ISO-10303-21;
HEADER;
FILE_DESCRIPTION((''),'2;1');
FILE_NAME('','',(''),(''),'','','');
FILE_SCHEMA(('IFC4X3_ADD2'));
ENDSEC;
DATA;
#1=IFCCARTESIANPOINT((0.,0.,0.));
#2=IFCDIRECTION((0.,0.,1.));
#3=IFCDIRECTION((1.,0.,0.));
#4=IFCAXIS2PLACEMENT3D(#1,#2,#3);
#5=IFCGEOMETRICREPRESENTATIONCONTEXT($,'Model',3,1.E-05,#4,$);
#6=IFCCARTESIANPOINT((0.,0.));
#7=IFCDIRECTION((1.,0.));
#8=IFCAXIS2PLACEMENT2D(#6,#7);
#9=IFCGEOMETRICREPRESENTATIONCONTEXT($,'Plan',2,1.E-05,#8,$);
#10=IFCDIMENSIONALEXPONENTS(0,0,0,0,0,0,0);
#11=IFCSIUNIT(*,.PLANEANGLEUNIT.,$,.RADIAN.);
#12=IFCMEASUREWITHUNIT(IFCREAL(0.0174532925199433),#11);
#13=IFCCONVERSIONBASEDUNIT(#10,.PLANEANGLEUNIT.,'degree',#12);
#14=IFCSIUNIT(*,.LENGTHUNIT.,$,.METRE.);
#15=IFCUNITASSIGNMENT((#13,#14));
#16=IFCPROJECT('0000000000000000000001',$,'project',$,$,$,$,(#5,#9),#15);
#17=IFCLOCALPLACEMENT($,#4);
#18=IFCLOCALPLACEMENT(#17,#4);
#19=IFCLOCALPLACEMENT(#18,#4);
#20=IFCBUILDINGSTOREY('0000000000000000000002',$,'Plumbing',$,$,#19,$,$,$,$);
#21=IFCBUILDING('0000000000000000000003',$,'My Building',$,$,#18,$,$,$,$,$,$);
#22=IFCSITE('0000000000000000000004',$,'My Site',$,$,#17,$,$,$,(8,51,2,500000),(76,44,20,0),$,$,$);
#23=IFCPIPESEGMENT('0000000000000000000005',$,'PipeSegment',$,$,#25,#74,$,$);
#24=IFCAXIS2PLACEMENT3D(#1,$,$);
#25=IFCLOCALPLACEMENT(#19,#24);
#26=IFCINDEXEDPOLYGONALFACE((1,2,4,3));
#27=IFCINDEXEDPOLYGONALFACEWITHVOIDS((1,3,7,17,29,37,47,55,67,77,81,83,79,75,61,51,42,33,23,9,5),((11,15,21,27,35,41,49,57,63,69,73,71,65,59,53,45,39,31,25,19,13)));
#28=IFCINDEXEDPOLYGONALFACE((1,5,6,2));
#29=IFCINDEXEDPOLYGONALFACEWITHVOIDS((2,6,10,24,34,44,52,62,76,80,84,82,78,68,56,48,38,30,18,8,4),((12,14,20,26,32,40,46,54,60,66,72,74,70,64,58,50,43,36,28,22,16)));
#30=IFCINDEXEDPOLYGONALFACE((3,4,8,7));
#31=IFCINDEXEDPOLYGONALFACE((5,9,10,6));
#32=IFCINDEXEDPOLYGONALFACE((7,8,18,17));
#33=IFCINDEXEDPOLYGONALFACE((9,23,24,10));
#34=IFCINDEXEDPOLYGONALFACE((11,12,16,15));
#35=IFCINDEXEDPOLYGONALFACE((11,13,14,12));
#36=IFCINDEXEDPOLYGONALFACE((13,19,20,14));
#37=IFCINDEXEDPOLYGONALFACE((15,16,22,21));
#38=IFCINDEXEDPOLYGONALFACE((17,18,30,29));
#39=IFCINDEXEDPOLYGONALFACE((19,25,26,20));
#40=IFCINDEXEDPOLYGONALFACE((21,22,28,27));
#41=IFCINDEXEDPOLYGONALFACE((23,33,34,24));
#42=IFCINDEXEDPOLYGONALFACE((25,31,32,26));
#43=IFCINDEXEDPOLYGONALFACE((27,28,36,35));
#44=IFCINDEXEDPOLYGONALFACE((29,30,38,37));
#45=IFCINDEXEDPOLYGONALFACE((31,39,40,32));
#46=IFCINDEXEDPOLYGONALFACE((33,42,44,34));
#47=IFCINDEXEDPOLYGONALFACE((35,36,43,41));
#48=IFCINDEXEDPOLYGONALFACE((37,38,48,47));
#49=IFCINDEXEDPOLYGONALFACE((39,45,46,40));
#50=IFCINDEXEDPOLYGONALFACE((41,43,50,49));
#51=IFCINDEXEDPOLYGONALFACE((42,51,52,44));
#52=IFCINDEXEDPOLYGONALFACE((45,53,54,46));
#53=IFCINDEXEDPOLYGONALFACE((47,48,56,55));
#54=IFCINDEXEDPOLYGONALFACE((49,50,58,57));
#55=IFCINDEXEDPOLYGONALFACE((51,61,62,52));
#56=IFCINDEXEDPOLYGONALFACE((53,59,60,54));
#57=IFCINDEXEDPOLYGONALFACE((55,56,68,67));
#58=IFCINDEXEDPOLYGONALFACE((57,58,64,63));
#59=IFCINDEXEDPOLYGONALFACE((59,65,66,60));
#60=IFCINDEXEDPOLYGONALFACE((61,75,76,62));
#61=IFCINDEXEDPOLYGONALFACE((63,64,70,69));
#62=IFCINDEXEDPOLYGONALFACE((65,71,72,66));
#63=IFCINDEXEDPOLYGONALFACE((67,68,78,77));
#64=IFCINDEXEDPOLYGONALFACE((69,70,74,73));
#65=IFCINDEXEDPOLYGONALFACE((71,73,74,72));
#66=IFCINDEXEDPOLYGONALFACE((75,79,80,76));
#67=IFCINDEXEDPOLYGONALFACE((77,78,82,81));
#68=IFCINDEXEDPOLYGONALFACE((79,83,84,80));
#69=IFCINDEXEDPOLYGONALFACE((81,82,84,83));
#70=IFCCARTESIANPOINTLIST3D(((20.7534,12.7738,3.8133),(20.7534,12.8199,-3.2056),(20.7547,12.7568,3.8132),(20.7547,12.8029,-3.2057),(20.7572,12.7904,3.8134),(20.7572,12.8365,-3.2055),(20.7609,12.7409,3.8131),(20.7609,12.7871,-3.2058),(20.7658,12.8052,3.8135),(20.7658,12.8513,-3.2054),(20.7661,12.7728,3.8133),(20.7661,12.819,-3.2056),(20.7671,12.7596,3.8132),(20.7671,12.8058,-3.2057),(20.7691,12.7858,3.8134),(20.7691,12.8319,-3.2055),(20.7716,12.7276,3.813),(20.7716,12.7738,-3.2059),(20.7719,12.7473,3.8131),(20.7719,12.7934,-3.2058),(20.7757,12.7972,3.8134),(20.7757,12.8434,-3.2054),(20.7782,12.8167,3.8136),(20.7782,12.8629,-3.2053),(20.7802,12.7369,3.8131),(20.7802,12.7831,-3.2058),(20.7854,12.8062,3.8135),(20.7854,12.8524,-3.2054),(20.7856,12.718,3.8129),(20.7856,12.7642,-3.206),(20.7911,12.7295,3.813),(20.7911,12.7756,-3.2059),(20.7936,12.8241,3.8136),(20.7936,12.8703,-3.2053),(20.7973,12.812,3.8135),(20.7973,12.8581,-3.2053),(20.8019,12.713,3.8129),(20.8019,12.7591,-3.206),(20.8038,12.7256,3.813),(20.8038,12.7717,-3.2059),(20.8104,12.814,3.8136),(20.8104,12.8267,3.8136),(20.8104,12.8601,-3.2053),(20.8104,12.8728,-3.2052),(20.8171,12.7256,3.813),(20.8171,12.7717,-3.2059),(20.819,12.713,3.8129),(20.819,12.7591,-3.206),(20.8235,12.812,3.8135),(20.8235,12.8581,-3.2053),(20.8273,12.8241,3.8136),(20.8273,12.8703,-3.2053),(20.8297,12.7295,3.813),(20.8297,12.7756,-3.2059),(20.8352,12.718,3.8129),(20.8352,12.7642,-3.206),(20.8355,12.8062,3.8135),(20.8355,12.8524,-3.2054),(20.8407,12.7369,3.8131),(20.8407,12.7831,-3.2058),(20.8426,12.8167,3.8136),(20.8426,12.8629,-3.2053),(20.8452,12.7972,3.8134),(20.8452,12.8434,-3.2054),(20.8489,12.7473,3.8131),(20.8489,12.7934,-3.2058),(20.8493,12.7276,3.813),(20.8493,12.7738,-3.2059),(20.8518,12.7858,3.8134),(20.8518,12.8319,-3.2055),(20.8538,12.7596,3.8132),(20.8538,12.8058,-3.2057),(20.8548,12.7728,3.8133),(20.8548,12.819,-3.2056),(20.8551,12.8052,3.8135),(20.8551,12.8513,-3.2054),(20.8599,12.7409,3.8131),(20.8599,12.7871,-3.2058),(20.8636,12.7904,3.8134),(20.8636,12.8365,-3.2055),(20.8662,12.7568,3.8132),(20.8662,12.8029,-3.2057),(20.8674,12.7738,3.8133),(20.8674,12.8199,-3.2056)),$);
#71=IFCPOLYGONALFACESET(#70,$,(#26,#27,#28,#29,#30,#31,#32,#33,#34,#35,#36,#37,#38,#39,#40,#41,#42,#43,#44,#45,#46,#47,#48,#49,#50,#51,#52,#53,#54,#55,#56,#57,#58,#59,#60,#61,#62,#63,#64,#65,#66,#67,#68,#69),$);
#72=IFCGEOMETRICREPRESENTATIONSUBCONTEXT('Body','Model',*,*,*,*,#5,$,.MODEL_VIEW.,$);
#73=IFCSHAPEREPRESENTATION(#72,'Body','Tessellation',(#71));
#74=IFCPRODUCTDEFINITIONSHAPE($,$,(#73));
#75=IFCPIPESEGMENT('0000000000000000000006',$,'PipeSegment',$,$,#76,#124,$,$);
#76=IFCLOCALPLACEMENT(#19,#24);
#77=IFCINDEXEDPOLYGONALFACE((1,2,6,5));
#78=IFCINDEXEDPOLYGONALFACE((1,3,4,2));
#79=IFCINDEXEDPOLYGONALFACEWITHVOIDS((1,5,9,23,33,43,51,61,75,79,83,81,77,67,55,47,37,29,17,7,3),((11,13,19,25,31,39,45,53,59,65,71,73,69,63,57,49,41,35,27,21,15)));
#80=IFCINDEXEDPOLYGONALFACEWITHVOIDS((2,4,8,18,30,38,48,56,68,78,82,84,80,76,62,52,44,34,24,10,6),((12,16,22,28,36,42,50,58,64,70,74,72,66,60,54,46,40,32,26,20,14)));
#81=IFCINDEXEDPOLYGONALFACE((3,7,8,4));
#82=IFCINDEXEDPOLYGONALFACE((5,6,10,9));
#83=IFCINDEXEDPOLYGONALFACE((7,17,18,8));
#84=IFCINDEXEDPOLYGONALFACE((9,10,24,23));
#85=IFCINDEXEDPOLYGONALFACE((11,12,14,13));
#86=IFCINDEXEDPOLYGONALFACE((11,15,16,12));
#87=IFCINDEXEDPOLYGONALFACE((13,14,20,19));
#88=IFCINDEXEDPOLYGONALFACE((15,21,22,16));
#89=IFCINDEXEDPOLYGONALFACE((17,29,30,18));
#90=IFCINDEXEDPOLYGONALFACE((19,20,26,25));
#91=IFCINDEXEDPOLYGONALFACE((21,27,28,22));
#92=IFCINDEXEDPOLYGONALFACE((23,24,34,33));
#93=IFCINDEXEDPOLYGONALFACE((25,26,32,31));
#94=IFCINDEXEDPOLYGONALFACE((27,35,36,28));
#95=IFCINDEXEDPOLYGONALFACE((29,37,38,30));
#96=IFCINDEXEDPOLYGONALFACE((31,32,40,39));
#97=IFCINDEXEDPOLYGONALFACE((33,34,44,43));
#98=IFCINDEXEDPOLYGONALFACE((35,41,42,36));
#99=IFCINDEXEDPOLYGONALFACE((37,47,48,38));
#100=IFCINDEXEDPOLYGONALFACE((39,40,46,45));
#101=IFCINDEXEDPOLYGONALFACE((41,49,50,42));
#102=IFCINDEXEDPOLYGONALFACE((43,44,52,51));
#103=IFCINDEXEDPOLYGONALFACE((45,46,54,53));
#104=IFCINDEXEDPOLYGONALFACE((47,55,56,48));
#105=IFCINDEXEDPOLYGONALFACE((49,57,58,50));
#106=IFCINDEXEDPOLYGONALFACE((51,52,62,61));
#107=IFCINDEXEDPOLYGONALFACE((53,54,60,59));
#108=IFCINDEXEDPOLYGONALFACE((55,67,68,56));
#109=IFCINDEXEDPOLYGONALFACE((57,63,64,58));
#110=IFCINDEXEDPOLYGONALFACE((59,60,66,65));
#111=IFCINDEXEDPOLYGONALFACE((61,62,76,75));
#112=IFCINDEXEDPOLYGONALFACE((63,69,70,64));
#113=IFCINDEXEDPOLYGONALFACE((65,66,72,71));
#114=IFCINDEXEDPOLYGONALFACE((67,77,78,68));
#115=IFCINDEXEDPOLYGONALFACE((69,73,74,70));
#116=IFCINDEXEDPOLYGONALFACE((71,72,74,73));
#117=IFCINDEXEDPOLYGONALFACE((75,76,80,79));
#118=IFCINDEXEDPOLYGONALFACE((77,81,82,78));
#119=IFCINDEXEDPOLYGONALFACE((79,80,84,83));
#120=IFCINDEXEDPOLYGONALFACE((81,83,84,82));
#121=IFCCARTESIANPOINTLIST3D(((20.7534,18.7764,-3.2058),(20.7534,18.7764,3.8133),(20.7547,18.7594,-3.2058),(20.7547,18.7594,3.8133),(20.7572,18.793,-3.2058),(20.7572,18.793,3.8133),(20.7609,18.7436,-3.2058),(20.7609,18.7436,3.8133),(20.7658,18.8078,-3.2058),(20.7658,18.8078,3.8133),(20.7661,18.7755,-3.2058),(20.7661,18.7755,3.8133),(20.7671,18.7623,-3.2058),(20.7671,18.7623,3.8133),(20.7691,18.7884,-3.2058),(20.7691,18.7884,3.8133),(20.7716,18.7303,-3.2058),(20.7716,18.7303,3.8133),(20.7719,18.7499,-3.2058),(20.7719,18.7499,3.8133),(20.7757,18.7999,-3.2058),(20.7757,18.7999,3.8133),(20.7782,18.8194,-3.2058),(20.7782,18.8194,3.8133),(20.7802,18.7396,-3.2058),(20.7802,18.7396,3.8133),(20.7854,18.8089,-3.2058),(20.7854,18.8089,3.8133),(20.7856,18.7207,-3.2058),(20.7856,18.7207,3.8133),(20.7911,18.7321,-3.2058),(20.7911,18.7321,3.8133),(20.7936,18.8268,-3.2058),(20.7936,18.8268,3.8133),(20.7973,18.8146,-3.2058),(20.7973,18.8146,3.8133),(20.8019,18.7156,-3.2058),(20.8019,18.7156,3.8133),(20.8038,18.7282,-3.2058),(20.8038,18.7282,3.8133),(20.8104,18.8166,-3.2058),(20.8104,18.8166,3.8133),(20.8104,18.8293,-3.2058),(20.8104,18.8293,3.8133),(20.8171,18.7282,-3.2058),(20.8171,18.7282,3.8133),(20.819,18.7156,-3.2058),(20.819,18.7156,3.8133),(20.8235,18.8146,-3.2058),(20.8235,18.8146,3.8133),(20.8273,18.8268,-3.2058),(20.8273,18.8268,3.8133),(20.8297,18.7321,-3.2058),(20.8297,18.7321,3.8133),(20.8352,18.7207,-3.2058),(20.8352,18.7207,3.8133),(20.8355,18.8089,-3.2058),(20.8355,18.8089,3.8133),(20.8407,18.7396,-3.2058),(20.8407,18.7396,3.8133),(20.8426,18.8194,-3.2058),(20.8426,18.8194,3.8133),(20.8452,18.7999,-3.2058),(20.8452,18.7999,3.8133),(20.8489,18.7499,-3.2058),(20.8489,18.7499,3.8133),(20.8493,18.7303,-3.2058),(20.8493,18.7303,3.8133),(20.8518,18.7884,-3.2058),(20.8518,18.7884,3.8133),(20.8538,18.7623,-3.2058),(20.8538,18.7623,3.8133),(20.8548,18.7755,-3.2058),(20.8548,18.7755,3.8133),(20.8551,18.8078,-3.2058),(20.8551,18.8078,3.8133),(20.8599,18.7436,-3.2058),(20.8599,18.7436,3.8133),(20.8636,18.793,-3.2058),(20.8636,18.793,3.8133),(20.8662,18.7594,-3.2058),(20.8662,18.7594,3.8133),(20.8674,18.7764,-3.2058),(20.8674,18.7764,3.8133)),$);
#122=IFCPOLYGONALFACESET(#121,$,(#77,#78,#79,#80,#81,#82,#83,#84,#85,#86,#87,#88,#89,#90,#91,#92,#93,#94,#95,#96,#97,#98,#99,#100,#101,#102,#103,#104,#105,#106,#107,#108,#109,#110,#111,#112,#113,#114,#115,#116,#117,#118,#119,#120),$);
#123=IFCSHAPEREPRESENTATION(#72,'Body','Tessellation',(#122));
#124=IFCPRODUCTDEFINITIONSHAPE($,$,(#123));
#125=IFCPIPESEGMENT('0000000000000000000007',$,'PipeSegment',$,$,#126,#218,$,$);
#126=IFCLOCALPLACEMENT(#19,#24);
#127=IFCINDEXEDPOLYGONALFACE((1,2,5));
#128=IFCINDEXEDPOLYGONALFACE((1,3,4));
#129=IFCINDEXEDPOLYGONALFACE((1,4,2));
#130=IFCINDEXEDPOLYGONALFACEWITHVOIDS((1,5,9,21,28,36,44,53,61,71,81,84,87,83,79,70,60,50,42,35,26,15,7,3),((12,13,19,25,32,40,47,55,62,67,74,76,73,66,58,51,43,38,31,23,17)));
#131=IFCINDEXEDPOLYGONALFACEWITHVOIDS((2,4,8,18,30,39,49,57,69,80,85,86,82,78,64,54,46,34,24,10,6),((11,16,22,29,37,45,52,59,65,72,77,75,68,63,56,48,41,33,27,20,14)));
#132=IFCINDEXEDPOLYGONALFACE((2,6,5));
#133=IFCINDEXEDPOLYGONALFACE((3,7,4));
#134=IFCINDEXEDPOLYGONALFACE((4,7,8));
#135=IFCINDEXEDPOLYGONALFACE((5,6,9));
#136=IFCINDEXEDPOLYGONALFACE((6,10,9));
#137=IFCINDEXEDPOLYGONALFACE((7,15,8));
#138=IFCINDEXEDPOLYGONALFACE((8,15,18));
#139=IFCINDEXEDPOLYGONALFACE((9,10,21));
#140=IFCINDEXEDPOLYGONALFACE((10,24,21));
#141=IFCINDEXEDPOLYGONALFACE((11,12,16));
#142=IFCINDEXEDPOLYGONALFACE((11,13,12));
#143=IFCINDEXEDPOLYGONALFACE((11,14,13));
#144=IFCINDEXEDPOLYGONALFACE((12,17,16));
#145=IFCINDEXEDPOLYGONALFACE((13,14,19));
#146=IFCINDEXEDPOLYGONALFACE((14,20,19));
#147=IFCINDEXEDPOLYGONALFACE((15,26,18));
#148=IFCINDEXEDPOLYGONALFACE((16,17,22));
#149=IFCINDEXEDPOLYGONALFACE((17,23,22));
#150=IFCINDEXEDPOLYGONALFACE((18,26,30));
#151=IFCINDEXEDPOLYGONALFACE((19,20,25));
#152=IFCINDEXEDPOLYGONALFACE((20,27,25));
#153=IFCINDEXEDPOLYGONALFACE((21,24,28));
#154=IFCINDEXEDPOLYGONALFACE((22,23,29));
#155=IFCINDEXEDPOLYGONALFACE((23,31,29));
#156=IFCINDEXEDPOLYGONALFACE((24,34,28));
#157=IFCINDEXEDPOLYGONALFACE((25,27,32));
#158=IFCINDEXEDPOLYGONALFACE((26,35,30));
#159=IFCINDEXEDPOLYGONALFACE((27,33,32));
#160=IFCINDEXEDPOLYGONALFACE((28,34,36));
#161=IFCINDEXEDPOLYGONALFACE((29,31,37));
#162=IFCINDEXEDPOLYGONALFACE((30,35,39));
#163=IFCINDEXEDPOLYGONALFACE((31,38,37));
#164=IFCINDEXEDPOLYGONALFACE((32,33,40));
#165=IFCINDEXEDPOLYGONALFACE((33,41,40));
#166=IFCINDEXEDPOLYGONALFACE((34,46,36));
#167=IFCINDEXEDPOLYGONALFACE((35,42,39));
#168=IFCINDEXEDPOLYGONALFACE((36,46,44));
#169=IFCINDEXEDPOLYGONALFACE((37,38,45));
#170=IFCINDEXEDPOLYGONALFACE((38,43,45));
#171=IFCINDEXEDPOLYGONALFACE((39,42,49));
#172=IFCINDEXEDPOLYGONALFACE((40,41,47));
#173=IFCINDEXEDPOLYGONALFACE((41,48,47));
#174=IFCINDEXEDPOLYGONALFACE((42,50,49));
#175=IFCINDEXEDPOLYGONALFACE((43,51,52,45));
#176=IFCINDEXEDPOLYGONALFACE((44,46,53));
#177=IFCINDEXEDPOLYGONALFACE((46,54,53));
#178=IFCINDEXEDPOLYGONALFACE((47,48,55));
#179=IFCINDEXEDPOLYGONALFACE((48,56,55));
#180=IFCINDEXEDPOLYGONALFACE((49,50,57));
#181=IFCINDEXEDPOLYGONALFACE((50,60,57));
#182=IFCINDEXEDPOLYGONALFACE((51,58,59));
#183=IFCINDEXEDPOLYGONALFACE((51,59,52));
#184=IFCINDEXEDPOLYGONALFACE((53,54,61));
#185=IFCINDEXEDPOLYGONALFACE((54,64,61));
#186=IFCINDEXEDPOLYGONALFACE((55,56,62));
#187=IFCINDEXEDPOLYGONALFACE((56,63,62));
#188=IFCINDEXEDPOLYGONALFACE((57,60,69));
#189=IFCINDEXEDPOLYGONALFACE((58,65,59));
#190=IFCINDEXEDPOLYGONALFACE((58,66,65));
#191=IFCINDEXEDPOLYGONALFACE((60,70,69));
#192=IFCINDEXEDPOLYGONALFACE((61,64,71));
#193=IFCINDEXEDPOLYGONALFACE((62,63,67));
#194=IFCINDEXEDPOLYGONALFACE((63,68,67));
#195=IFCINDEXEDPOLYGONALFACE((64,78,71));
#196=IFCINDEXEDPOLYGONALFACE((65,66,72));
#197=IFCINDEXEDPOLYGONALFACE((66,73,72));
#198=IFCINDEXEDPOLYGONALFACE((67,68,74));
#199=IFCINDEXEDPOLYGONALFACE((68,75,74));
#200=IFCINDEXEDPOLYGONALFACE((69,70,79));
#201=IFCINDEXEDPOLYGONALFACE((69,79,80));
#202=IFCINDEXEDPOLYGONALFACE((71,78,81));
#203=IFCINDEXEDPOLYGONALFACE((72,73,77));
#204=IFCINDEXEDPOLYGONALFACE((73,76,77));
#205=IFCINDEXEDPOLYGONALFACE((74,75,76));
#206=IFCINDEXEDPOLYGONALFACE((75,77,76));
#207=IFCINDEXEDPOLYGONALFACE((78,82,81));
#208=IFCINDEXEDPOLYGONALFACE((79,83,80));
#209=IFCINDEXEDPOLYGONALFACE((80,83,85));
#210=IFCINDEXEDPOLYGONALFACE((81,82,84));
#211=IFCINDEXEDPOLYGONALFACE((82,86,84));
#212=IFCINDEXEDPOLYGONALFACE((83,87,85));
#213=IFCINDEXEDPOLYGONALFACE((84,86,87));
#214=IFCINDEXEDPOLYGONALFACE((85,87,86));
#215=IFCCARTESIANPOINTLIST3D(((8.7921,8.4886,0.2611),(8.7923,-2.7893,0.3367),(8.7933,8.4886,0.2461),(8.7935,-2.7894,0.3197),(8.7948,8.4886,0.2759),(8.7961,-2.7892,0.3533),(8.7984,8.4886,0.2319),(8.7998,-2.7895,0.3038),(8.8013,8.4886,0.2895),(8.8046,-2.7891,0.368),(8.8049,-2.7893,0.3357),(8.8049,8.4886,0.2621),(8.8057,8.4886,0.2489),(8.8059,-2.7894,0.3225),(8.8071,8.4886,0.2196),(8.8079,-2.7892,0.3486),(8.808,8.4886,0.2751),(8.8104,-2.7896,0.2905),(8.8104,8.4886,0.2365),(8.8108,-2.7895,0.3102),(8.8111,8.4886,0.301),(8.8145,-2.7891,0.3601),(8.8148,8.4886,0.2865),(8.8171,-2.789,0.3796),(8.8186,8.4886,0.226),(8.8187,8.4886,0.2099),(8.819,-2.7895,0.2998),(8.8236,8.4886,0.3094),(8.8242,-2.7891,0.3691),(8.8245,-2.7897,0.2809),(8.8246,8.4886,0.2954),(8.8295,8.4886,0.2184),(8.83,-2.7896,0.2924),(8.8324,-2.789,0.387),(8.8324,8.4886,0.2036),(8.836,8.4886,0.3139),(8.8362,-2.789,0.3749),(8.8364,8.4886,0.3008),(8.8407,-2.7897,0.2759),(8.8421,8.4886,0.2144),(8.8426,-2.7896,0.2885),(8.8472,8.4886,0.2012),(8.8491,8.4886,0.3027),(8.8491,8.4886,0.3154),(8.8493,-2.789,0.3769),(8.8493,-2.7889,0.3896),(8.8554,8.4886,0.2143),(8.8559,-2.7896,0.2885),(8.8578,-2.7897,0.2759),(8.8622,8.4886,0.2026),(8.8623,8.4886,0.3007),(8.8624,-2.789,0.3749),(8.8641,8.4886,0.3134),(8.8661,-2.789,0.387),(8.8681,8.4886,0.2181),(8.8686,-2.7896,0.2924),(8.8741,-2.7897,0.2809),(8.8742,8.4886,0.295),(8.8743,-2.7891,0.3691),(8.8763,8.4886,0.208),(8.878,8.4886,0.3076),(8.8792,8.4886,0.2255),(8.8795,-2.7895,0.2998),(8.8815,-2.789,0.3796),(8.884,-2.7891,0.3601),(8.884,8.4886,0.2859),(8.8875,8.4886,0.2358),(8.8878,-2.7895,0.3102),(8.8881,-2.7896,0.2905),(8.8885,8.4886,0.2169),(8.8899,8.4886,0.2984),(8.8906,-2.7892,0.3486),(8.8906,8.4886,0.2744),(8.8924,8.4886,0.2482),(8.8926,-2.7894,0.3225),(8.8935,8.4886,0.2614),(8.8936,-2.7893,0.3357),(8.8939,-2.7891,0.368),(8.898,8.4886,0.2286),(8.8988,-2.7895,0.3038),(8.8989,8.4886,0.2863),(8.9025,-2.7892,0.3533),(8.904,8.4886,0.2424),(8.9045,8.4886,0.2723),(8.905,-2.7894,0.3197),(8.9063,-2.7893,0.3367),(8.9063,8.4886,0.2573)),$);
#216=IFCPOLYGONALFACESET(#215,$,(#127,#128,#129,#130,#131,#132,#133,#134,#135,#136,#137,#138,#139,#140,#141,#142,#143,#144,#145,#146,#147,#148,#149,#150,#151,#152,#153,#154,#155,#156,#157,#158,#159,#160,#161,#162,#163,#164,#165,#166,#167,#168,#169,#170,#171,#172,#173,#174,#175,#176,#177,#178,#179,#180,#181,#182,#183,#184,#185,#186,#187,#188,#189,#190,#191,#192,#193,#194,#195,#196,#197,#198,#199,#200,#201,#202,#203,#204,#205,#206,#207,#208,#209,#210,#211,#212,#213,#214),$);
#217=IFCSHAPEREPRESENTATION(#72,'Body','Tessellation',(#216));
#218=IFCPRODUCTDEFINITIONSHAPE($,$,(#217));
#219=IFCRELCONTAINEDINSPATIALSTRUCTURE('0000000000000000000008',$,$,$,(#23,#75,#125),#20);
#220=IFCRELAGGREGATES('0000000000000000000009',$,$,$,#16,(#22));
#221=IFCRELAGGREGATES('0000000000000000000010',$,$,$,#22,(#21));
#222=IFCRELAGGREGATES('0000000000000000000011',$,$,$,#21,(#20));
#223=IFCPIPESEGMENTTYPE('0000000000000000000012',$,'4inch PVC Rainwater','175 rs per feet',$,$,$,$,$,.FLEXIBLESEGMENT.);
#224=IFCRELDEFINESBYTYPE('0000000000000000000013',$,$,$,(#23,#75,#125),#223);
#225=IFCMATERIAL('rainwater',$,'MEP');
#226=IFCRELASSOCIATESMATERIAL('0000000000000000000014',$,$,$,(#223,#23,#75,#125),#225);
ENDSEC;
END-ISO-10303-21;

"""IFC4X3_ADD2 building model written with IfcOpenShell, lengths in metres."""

from ifc_helpers import new_model, entity, si_unit, converted_unit, frame, origin_with_axes, origin_2d_with_axis, place, context, subcontext, project, spatial, hollow_circle, extrude, clip, halfspace, material, material_profile, profile_set, profile_usage, type_object, element, save


model = new_model("IFC4X3_ADD2")

# Units and contexts
model_context = context("Model", 3, precision=1e-05, world=origin_with_axes())
plan_context = context("Plan", 2, precision=1e-05, world=origin_2d_with_axis())
body_context = subcontext(model_context, "Body", "Model", "MODEL_VIEW")
ifc_project = project(units=[converted_unit("PLANEANGLEUNIT", "degree", entity("IfcReal", 0.0174532925199433), si_unit("PLANEANGLEUNIT", "RADIAN"), dimensions=[0, 0, 0, 0, 0, 0, 0]), si_unit("LENGTHUNIT", "METRE")], contexts=[model_context, plan_context])

# Site, building, storey
site_placement = place(None, origin_with_axes())
site = spatial("IfcSite", under=ifc_project, at=site_placement, Name="My Site", RefLatitude=(8, 51, 2, 500000), RefLongitude=(76, 44, 20, 0))
building_placement = place(site_placement, origin_with_axes())
building = spatial("IfcBuilding", under=site, at=building_placement, Name="My Building")
storey_placement = place(building_placement, origin_with_axes())
storey = spatial("IfcBuildingStorey", under=building, at=storey_placement, Name="Plumbing")

# Pipe segments
ifc_material_1 = material(Name="rainwater", Category="MEP")
ifc_material_profile_1 = material_profile(ifc_material_1, hollow_circle(Radius=0.0571, WallThickness=0.0127))
ifc_profile_set_1 = profile_set([ifc_material_profile_1], Name="rainwater")
ifc_profile_usage_1 = profile_usage(ifc_profile_set_1)
pipe_segment_type_1 = type_object("IfcPipeSegmentType", Name="4inch PVC Rainwater", Description="175 rs per feet", PredefinedType="FLEXIBLESEGMENT", material=ifc_profile_set_1)
pipe_segment_1_placement = place(storey_placement, frame((20.8104, 12.7695, 3.8133), z_axis=(0.0, 0.006573, -0.999978), x_axis=(0.0, 0.999978, 0.006573)))
element("IfcPipeSegment", 1, at=pipe_segment_1_placement, inside=storey, type_object=pipe_segment_type_1, material=ifc_profile_usage_1, Name="PipeSegment", context=body_context, shape_type="SweptSolid", body=[
    extrude(hollow_circle(Radius=0.0571, WallThickness=0.0127), origin_with_axes(), (0.0, 0.0, 1.0), 7.019),
])
ifc_profile_usage_2 = profile_usage(ifc_profile_set_1)
pipe_segment_2_placement = place(storey_placement, frame((20.8104, 18.7722, 3.8133), z_axis=(0.0, 0.0, -1.0), x_axis=(0.000001, 1.0, 0.0)))
element("IfcPipeSegment", 2, at=pipe_segment_2_placement, inside=storey, type_object=pipe_segment_type_1, material=ifc_profile_usage_2, Name="PipeSegment", context=body_context, shape_type="SweptSolid", body=[
    extrude(hollow_circle(Radius=0.0571, WallThickness=0.0127), origin_with_axes(), (0.0, 0.0, 1.0), 7.019),
])
ifc_profile_usage_3 = profile_usage(ifc_profile_set_1)
pipe_segment_3_placement = place(storey_placement, frame((8.8491, 8.6029, 0.2575), z_axis=(0.000011, -0.999978, 0.006573), x_axis=(-0.000001, 0.006573, 0.999978)))
element("IfcPipeSegment", 3, at=pipe_segment_3_placement, inside=storey, type_object=pipe_segment_type_1, material=ifc_profile_usage_3, Name="PipeSegment", context=body_context, shape_type="Clipping", body=[
    clip(extrude(hollow_circle(Radius=0.0571, WallThickness=0.0127), origin_with_axes(), (0.0, 0.0, 1.0), 11.3924), halfspace(frame((-0.0107, 0.0574, 0.1142), z_axis=(0.006574, -0.000011, -0.999978), x_axis=(0.999978, 0.0, 0.006574)), False)),
])

save(model, "model.ifc")
